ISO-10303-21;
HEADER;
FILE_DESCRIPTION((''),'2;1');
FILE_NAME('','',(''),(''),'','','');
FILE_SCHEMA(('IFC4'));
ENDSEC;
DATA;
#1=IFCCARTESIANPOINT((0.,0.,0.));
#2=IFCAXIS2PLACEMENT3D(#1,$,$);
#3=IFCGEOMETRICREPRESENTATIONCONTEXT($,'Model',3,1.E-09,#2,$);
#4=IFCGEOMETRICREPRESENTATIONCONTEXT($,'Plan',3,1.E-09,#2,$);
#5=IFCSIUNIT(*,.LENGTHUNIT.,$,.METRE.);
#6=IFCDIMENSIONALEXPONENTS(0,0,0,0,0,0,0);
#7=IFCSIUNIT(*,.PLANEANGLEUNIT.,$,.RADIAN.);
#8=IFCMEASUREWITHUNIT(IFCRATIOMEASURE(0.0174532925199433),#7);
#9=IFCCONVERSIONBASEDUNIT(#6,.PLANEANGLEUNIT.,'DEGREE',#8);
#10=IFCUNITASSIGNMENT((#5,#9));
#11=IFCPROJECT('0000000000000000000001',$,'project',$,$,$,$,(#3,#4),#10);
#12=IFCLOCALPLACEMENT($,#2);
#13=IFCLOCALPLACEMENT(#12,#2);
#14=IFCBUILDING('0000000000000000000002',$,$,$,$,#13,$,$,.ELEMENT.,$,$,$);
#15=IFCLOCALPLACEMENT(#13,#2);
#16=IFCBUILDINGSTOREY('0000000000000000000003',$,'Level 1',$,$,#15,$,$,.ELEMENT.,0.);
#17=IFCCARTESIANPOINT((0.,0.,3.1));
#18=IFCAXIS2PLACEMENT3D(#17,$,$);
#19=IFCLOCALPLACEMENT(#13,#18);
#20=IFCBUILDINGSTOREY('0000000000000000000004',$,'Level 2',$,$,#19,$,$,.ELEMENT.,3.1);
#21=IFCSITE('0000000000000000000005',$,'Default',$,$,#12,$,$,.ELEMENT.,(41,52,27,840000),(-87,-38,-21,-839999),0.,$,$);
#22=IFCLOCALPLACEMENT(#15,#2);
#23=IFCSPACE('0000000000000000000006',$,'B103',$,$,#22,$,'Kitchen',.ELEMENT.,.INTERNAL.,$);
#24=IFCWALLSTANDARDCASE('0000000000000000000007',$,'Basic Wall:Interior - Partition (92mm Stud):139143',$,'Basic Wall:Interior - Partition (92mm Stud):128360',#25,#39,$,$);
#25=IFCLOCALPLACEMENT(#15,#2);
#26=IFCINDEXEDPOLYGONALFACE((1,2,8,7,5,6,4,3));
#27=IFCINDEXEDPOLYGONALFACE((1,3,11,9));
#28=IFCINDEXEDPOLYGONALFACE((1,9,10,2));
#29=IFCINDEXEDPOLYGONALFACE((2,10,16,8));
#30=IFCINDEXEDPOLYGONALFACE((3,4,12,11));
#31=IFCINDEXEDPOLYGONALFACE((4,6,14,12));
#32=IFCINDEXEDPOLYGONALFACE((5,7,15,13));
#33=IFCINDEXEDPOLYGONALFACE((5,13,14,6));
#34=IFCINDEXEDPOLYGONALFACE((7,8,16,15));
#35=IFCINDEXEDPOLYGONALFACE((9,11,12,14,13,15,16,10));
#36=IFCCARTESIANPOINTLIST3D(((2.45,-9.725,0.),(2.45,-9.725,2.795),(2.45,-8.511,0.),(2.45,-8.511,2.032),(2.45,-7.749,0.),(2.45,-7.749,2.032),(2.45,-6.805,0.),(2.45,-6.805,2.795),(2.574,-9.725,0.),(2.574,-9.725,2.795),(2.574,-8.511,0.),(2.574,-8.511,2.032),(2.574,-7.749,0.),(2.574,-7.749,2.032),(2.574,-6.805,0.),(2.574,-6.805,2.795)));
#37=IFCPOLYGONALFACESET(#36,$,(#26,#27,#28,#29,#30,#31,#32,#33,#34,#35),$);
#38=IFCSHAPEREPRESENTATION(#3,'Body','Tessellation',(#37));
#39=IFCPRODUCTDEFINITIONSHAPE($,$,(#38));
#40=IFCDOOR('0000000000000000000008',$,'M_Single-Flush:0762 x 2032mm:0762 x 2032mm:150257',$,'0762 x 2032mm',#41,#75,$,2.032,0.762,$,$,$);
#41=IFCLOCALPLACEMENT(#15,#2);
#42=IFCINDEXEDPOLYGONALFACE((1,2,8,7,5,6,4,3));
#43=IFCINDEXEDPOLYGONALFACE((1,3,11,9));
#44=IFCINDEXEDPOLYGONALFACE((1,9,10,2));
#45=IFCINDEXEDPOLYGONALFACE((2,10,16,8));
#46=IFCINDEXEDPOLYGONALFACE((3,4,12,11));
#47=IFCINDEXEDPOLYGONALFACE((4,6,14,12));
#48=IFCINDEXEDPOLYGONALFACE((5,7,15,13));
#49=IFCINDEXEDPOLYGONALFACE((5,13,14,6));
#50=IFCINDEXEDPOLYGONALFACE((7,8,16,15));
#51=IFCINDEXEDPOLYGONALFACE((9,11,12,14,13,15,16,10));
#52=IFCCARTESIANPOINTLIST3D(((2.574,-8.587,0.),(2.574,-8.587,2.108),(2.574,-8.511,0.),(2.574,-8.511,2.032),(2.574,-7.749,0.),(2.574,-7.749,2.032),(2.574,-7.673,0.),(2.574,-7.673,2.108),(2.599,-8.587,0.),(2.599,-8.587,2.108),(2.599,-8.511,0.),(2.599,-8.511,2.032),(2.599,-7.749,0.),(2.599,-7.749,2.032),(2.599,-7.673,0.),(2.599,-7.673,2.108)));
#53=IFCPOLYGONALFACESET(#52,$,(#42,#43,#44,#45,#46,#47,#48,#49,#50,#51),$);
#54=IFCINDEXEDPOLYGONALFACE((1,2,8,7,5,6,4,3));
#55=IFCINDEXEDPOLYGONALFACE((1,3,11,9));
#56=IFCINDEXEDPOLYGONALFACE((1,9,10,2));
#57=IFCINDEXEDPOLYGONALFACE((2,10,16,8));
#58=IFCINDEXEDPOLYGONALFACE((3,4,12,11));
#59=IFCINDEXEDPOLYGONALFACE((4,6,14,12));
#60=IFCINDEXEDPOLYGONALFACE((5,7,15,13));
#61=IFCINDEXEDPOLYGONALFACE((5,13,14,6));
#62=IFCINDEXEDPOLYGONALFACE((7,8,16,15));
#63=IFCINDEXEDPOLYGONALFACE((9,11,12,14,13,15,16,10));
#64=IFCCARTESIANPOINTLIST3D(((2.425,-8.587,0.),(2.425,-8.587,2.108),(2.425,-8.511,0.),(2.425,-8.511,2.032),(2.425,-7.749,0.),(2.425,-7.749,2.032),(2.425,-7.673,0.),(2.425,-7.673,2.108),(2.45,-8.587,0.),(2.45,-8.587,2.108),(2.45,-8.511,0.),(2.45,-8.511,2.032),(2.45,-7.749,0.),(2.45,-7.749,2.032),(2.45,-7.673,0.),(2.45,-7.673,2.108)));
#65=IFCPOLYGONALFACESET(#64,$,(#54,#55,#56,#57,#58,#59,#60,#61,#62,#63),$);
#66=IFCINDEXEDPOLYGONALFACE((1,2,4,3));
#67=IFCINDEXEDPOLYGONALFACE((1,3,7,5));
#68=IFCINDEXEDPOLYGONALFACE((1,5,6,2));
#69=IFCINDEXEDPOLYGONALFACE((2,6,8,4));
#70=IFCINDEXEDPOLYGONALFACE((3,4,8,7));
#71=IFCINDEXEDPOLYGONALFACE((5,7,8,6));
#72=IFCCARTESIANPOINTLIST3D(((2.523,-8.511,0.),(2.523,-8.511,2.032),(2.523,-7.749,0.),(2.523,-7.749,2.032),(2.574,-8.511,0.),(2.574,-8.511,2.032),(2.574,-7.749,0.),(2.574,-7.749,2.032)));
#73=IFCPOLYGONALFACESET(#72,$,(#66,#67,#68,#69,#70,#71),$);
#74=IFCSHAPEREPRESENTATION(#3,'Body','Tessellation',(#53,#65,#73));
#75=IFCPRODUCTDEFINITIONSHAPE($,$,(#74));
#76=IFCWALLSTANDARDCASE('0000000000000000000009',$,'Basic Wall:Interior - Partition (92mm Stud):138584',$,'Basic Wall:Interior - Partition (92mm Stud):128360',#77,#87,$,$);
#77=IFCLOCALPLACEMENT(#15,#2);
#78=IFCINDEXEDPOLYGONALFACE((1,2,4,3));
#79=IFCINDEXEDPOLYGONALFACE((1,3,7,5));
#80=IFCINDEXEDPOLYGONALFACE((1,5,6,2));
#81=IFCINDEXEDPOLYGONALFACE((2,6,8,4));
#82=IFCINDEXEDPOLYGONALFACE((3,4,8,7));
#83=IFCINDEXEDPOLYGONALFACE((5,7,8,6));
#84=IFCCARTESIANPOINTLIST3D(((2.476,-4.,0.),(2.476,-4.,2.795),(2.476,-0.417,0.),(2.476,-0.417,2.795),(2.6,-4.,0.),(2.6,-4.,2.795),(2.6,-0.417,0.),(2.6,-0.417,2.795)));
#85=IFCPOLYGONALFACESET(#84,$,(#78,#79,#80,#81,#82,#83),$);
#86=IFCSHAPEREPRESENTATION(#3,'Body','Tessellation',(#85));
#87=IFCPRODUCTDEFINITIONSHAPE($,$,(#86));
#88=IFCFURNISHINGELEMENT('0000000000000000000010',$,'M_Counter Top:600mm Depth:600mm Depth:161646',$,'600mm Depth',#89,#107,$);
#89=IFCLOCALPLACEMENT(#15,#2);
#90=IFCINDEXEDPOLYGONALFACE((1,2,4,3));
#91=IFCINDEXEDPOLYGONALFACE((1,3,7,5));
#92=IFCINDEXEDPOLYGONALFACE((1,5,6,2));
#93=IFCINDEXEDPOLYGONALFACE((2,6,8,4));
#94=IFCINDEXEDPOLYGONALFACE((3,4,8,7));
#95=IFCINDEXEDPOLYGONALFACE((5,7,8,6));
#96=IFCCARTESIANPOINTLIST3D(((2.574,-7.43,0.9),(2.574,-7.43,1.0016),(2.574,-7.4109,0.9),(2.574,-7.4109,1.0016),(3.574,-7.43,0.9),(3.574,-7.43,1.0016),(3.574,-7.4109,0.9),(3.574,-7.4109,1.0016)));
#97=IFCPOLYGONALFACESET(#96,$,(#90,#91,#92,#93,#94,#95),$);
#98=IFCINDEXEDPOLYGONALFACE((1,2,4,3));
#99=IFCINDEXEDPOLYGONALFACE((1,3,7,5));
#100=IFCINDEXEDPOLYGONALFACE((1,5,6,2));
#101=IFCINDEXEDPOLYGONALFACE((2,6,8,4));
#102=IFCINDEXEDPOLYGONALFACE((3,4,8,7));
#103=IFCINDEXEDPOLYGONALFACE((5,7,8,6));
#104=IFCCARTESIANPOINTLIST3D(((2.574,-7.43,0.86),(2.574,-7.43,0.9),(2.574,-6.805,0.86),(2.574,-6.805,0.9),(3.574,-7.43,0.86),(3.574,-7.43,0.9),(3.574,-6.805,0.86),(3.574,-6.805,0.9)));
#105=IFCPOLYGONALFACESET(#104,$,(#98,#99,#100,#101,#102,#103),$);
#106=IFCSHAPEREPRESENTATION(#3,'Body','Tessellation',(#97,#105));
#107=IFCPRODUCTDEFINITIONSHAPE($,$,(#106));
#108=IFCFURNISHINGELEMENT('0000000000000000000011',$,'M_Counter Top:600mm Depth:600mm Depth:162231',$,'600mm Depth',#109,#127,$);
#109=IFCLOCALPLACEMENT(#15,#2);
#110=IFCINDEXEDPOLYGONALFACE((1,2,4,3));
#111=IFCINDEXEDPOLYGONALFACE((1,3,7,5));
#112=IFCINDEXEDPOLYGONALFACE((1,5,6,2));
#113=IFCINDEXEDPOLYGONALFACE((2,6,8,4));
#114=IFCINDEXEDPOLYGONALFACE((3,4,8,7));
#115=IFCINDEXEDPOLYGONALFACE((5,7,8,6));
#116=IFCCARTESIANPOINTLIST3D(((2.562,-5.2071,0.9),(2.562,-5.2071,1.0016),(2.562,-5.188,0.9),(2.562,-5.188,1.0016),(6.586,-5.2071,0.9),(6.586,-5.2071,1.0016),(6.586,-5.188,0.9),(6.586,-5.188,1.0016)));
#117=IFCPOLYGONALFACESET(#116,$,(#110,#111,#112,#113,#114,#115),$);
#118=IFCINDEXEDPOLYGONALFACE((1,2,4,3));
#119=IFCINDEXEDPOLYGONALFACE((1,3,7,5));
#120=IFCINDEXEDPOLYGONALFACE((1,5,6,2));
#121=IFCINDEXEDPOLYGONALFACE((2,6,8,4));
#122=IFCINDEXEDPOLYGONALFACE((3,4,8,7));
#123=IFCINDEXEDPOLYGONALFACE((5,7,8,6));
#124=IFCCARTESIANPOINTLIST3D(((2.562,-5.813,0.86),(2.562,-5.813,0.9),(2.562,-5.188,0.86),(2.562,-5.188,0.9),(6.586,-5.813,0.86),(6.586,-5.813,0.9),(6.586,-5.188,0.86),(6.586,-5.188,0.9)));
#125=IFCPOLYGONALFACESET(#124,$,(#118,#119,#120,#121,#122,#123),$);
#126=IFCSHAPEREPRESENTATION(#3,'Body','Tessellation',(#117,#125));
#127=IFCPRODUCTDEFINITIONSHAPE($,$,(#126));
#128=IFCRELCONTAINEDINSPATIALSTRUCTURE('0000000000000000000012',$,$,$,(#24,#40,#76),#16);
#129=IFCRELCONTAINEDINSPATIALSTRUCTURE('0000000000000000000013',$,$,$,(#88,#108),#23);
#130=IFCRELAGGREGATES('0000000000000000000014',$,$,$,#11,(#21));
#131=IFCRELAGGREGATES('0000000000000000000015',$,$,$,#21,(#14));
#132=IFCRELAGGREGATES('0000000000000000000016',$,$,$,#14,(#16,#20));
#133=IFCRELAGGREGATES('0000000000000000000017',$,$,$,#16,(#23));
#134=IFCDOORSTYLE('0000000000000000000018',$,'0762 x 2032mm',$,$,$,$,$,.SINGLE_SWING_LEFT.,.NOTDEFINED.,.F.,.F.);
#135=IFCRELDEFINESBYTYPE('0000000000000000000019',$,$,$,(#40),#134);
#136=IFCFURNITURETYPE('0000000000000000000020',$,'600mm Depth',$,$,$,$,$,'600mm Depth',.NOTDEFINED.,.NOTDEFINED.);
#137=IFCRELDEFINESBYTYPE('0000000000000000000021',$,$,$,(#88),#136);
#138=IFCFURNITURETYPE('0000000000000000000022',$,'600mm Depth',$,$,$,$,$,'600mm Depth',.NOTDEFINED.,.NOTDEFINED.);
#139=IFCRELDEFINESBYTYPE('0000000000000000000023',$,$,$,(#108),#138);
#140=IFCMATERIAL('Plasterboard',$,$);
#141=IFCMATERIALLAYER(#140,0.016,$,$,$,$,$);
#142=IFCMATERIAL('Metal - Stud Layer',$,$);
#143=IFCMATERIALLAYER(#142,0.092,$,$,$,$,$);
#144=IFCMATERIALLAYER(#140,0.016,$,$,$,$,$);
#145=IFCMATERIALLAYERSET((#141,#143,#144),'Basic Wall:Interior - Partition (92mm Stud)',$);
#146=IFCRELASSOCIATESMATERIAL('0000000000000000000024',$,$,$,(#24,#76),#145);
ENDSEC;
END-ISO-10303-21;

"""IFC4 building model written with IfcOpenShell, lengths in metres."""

from ifc_helpers import new_model, entity, si_unit, converted_unit, frame, frame_2d, origin, origin_2d_with_axis, place, context, project, spatial, polyline, rectangle, outline, extrude, source, transform, mapped, material, layer, layer_set, layer_usage, type_object, type_shapes, element, fill, save


model = new_model("IFC4")

# Units and contexts
model_context = context("Model", 3, precision=1e-09, world=origin())
plan_context = context("Plan", 3, precision=1e-09, world=origin())
ifc_project = project(units=[si_unit("LENGTHUNIT", "METRE"), converted_unit("PLANEANGLEUNIT", "DEGREE", entity("IfcRatioMeasure", 0.0174532925199433), si_unit("PLANEANGLEUNIT", "RADIAN"), dimensions=[0, 0, 0, 0, 0, 0, 0])], contexts=[model_context, plan_context])

# Site, building, storey
site_placement = place(None, origin())
site = spatial("IfcSite", under=ifc_project, at=site_placement, Name="Default", CompositionType="ELEMENT", RefLatitude=(41, 52, 27, 840000), RefLongitude=(-87, -38, -21, -839999), RefElevation=0.0)
building_placement = place(site_placement, origin())
building = spatial("IfcBuilding", under=site, at=building_placement, CompositionType="ELEMENT")
storey_1_placement = place(building_placement, origin())
storey_1 = spatial("IfcBuildingStorey", under=building, at=storey_1_placement, Name="Level 1", CompositionType="ELEMENT", Elevation=0.0)

# Shared definitions
ifc_material_1 = material(Name="Metal - Stud Layer")
ifc_material_2 = material(Name="Plasterboard")

# Shared definitions
ifc_layer_1 = layer(ifc_material_2, 0.016)
ifc_layer_2 = layer(ifc_material_1, 0.092)
ifc_layer_3 = layer(ifc_material_2, 0.016)
ifc_layer_set_1 = layer_set([ifc_layer_1, ifc_layer_2, ifc_layer_3], Name="Basic Wall:Interior - Partition (92mm Stud)")

# Shared definitions
storey_2_placement = place(building_placement, frame((0.0, 0.0, 3.1)))
storey_2 = spatial("IfcBuildingStorey", under=building, at=storey_2_placement, Name="Level 2", CompositionType="ELEMENT", Elevation=3.1)

# Wall, opening, door
ifc_layer_usage_1 = layer_usage(ifc_layer_set_1, "AXIS2", "NEGATIVE", 0.062)
wall_1_placement = place(storey_1_placement, frame((2.512, -6.805, 0.0), z_axis=(0.0, 0.0, 1.0), x_axis=(0.0, -1.0, 0.0)))
wall_1 = element("IfcWallStandardCase", 1, at=wall_1_placement, inside=storey_1, material=ifc_layer_usage_1, Name="Basic Wall:Interior - Partition (92mm Stud):139143", ObjectType="Basic Wall:Interior - Partition (92mm Stud):128360", context=model_context, shape_type="SweptSolid", body=[
    extrude(rectangle(XDim=2.92, YDim=0.124, at=frame_2d((1.46, 0.0), x_axis=(-1.0, 0.0))), origin(), (0.0, 0.0, 1.0), 2.795),
])
opening_1_placement = place(wall_1_placement, frame((0.944, -0.062, 0.0)))
opening_1 = element("IfcOpeningElement", 2, at=opening_1_placement, cuts=wall_1, ObjectType="Opening", context=model_context, shape_type="SweptSolid", body=[
    extrude(rectangle(XDim=0.762, YDim=2.032, at=frame_2d((1.016, 0.381), x_axis=(0.0, -1.0))), frame((0.0, 0.0, 0.0), z_axis=(0.0, 1.0, 0.0), x_axis=(0.0, 0.0, 1.0)), (0.0, 0.0, 1.0), 0.124),
])
door_style_1 = type_object("IfcDoorStyle", Name="0762 x 2032mm", ConstructionType="NOTDEFINED", OperationType="SINGLE_SWING_LEFT", ParameterTakesPrecedence=False, Sizeable=False)
shared_shape_1 = source(origin(), model_context, "Body", "SweptSolid", [
    extrude(outline(polyline([(-0.457, -1.073), (0.457, -1.073), (0.457, 1.035), (0.381, 1.035), (0.381, -0.997), (-0.381, -0.997), (-0.381, 1.035), (-0.457, 1.035), (-0.457, -1.073)])), frame((0.381, 0.149, 1.035), z_axis=(0.0, -1.0, 0.0), x_axis=(-1.0, 0.0, 0.0)), (0.0, 0.0, 1.0), 0.025),
    extrude(outline(polyline([(-1.073, -0.457), (1.035, -0.457), (1.035, -0.381), (-0.997, -0.381), (-0.997, 0.381), (1.035, 0.381), (1.035, 0.457), (-1.073, 0.457), (-1.073, -0.457)])), frame((0.381, 0.0, 1.035), z_axis=(0.0, -1.0, 0.0), x_axis=(0.0, 0.0, -1.0)), (0.0, 0.0, 1.0), 0.025),
    extrude(rectangle(XDim=0.762, YDim=0.051, at=origin_2d_with_axis()), frame((0.381, 0.0985, 0.0)), (0.0, 0.0, 1.0), 2.032),
])
type_shapes(door_style_1, [shared_shape_1])
door_1_placement = place(opening_1_placement, origin())
door_1 = element("IfcDoor", 3, at=door_1_placement, inside=storey_1, type_object=door_style_1, Name="M_Single-Flush:0762 x 2032mm:0762 x 2032mm:150257", ObjectType="0762 x 2032mm", OverallHeight=2.032, OverallWidth=0.762, context=model_context, shape_type="MappedRepresentation", body=[
    mapped(shared_shape_1, transform((0.0, 0.0, 0.0), scale=1.0)),
])
fill(opening_1, door_1)

# Wall
ifc_layer_usage_2 = layer_usage(ifc_layer_set_1, "AXIS2", "NEGATIVE", 0.062)
wall_2_placement = place(storey_1_placement, frame((2.538, -0.417, 0.0), z_axis=(0.0, 0.0, 1.0), x_axis=(0.0, -1.0, 0.0)))
element("IfcWallStandardCase", 4, at=wall_2_placement, inside=storey_1, material=ifc_layer_usage_2, Name="Basic Wall:Interior - Partition (92mm Stud):138584", ObjectType="Basic Wall:Interior - Partition (92mm Stud):128360", context=model_context, shape_type="SweptSolid", body=[
    extrude(rectangle(XDim=3.583, YDim=0.124, at=frame_2d((1.7915, 0.0), x_axis=(-1.0, 0.0))), origin(), (0.0, 0.0, 1.0), 2.795),
])

# Shared definitions
space_1_placement = place(storey_1_placement, origin())
space_1 = spatial("IfcSpace", under=storey_1, at=space_1_placement, Name="B103", LongName="Kitchen", CompositionType="ELEMENT", PredefinedType="INTERNAL")

# Furnishing elements
furniture_type_1 = type_object("IfcFurnitureType", Name="600mm Depth", ElementType="600mm Depth", AssemblyPlace="NOTDEFINED")
shared_shape_2 = source(origin(), model_context, "Body", "SweptSolid", [
    extrude(rectangle(XDim=0.0191, YDim=1.0, at=origin_2d_with_axis()), frame((-0.7005, -0.0095, 0.9), z_axis=(0.0, 0.0, 1.0), x_axis=(0.0, -1.0, 0.0)), (0.0, 0.0, 1.0), 0.1016),
    extrude(rectangle(XDim=1.0, YDim=0.625, at=origin_2d_with_axis()), frame((-0.7005, -0.3125, 0.86), z_axis=(0.0, 0.0, 1.0), x_axis=(-1.0, 0.0, 0.0)), (0.0, 0.0, 1.0), 0.04),
])
type_shapes(furniture_type_1, [shared_shape_2])
furnishing_1_placement = place(space_1_placement, frame((2.3735, -7.43, 0.0), z_axis=(0.0, 0.0, 1.0), x_axis=(-1.0, 0.0, 0.0)))
element("IfcFurnishingElement", 5, at=furnishing_1_placement, inside=space_1, type_object=furniture_type_1, Name="M_Counter Top:600mm Depth:600mm Depth:161646", ObjectType="600mm Depth", context=model_context, shape_type="MappedRepresentation", body=[
    mapped(shared_shape_2, transform((0.0, 0.0, 0.0), scale=1.0)),
])
furniture_type_2 = type_object("IfcFurnitureType", Name="600mm Depth", ElementType="600mm Depth", AssemblyPlace="NOTDEFINED")
shared_shape_3 = source(origin(), model_context, "Body", "SweptSolid", [
    extrude(rectangle(XDim=0.0191, YDim=4.024, at=origin_2d_with_axis()), frame((0.8115, -0.0095, 0.9), z_axis=(0.0, 0.0, 1.0), x_axis=(0.0, -1.0, 0.0)), (0.0, 0.0, 1.0), 0.1016),
    extrude(rectangle(XDim=4.024, YDim=0.625, at=origin_2d_with_axis()), frame((0.8115, -0.3125, 0.86), z_axis=(0.0, 0.0, 1.0), x_axis=(-1.0, 0.0, 0.0)), (0.0, 0.0, 1.0), 0.04),
])
type_shapes(furniture_type_2, [shared_shape_3])
furnishing_2_placement = place(space_1_placement, frame((3.7625, -5.188, 0.0)))
element("IfcFurnishingElement", 6, at=furnishing_2_placement, inside=space_1, type_object=furniture_type_2, Name="M_Counter Top:600mm Depth:600mm Depth:162231", ObjectType="600mm Depth", context=model_context, shape_type="MappedRepresentation", body=[
    mapped(shared_shape_3, transform((0.0, 0.0, 0.0), scale=1.0)),
])

save(model, "model.ifc")
